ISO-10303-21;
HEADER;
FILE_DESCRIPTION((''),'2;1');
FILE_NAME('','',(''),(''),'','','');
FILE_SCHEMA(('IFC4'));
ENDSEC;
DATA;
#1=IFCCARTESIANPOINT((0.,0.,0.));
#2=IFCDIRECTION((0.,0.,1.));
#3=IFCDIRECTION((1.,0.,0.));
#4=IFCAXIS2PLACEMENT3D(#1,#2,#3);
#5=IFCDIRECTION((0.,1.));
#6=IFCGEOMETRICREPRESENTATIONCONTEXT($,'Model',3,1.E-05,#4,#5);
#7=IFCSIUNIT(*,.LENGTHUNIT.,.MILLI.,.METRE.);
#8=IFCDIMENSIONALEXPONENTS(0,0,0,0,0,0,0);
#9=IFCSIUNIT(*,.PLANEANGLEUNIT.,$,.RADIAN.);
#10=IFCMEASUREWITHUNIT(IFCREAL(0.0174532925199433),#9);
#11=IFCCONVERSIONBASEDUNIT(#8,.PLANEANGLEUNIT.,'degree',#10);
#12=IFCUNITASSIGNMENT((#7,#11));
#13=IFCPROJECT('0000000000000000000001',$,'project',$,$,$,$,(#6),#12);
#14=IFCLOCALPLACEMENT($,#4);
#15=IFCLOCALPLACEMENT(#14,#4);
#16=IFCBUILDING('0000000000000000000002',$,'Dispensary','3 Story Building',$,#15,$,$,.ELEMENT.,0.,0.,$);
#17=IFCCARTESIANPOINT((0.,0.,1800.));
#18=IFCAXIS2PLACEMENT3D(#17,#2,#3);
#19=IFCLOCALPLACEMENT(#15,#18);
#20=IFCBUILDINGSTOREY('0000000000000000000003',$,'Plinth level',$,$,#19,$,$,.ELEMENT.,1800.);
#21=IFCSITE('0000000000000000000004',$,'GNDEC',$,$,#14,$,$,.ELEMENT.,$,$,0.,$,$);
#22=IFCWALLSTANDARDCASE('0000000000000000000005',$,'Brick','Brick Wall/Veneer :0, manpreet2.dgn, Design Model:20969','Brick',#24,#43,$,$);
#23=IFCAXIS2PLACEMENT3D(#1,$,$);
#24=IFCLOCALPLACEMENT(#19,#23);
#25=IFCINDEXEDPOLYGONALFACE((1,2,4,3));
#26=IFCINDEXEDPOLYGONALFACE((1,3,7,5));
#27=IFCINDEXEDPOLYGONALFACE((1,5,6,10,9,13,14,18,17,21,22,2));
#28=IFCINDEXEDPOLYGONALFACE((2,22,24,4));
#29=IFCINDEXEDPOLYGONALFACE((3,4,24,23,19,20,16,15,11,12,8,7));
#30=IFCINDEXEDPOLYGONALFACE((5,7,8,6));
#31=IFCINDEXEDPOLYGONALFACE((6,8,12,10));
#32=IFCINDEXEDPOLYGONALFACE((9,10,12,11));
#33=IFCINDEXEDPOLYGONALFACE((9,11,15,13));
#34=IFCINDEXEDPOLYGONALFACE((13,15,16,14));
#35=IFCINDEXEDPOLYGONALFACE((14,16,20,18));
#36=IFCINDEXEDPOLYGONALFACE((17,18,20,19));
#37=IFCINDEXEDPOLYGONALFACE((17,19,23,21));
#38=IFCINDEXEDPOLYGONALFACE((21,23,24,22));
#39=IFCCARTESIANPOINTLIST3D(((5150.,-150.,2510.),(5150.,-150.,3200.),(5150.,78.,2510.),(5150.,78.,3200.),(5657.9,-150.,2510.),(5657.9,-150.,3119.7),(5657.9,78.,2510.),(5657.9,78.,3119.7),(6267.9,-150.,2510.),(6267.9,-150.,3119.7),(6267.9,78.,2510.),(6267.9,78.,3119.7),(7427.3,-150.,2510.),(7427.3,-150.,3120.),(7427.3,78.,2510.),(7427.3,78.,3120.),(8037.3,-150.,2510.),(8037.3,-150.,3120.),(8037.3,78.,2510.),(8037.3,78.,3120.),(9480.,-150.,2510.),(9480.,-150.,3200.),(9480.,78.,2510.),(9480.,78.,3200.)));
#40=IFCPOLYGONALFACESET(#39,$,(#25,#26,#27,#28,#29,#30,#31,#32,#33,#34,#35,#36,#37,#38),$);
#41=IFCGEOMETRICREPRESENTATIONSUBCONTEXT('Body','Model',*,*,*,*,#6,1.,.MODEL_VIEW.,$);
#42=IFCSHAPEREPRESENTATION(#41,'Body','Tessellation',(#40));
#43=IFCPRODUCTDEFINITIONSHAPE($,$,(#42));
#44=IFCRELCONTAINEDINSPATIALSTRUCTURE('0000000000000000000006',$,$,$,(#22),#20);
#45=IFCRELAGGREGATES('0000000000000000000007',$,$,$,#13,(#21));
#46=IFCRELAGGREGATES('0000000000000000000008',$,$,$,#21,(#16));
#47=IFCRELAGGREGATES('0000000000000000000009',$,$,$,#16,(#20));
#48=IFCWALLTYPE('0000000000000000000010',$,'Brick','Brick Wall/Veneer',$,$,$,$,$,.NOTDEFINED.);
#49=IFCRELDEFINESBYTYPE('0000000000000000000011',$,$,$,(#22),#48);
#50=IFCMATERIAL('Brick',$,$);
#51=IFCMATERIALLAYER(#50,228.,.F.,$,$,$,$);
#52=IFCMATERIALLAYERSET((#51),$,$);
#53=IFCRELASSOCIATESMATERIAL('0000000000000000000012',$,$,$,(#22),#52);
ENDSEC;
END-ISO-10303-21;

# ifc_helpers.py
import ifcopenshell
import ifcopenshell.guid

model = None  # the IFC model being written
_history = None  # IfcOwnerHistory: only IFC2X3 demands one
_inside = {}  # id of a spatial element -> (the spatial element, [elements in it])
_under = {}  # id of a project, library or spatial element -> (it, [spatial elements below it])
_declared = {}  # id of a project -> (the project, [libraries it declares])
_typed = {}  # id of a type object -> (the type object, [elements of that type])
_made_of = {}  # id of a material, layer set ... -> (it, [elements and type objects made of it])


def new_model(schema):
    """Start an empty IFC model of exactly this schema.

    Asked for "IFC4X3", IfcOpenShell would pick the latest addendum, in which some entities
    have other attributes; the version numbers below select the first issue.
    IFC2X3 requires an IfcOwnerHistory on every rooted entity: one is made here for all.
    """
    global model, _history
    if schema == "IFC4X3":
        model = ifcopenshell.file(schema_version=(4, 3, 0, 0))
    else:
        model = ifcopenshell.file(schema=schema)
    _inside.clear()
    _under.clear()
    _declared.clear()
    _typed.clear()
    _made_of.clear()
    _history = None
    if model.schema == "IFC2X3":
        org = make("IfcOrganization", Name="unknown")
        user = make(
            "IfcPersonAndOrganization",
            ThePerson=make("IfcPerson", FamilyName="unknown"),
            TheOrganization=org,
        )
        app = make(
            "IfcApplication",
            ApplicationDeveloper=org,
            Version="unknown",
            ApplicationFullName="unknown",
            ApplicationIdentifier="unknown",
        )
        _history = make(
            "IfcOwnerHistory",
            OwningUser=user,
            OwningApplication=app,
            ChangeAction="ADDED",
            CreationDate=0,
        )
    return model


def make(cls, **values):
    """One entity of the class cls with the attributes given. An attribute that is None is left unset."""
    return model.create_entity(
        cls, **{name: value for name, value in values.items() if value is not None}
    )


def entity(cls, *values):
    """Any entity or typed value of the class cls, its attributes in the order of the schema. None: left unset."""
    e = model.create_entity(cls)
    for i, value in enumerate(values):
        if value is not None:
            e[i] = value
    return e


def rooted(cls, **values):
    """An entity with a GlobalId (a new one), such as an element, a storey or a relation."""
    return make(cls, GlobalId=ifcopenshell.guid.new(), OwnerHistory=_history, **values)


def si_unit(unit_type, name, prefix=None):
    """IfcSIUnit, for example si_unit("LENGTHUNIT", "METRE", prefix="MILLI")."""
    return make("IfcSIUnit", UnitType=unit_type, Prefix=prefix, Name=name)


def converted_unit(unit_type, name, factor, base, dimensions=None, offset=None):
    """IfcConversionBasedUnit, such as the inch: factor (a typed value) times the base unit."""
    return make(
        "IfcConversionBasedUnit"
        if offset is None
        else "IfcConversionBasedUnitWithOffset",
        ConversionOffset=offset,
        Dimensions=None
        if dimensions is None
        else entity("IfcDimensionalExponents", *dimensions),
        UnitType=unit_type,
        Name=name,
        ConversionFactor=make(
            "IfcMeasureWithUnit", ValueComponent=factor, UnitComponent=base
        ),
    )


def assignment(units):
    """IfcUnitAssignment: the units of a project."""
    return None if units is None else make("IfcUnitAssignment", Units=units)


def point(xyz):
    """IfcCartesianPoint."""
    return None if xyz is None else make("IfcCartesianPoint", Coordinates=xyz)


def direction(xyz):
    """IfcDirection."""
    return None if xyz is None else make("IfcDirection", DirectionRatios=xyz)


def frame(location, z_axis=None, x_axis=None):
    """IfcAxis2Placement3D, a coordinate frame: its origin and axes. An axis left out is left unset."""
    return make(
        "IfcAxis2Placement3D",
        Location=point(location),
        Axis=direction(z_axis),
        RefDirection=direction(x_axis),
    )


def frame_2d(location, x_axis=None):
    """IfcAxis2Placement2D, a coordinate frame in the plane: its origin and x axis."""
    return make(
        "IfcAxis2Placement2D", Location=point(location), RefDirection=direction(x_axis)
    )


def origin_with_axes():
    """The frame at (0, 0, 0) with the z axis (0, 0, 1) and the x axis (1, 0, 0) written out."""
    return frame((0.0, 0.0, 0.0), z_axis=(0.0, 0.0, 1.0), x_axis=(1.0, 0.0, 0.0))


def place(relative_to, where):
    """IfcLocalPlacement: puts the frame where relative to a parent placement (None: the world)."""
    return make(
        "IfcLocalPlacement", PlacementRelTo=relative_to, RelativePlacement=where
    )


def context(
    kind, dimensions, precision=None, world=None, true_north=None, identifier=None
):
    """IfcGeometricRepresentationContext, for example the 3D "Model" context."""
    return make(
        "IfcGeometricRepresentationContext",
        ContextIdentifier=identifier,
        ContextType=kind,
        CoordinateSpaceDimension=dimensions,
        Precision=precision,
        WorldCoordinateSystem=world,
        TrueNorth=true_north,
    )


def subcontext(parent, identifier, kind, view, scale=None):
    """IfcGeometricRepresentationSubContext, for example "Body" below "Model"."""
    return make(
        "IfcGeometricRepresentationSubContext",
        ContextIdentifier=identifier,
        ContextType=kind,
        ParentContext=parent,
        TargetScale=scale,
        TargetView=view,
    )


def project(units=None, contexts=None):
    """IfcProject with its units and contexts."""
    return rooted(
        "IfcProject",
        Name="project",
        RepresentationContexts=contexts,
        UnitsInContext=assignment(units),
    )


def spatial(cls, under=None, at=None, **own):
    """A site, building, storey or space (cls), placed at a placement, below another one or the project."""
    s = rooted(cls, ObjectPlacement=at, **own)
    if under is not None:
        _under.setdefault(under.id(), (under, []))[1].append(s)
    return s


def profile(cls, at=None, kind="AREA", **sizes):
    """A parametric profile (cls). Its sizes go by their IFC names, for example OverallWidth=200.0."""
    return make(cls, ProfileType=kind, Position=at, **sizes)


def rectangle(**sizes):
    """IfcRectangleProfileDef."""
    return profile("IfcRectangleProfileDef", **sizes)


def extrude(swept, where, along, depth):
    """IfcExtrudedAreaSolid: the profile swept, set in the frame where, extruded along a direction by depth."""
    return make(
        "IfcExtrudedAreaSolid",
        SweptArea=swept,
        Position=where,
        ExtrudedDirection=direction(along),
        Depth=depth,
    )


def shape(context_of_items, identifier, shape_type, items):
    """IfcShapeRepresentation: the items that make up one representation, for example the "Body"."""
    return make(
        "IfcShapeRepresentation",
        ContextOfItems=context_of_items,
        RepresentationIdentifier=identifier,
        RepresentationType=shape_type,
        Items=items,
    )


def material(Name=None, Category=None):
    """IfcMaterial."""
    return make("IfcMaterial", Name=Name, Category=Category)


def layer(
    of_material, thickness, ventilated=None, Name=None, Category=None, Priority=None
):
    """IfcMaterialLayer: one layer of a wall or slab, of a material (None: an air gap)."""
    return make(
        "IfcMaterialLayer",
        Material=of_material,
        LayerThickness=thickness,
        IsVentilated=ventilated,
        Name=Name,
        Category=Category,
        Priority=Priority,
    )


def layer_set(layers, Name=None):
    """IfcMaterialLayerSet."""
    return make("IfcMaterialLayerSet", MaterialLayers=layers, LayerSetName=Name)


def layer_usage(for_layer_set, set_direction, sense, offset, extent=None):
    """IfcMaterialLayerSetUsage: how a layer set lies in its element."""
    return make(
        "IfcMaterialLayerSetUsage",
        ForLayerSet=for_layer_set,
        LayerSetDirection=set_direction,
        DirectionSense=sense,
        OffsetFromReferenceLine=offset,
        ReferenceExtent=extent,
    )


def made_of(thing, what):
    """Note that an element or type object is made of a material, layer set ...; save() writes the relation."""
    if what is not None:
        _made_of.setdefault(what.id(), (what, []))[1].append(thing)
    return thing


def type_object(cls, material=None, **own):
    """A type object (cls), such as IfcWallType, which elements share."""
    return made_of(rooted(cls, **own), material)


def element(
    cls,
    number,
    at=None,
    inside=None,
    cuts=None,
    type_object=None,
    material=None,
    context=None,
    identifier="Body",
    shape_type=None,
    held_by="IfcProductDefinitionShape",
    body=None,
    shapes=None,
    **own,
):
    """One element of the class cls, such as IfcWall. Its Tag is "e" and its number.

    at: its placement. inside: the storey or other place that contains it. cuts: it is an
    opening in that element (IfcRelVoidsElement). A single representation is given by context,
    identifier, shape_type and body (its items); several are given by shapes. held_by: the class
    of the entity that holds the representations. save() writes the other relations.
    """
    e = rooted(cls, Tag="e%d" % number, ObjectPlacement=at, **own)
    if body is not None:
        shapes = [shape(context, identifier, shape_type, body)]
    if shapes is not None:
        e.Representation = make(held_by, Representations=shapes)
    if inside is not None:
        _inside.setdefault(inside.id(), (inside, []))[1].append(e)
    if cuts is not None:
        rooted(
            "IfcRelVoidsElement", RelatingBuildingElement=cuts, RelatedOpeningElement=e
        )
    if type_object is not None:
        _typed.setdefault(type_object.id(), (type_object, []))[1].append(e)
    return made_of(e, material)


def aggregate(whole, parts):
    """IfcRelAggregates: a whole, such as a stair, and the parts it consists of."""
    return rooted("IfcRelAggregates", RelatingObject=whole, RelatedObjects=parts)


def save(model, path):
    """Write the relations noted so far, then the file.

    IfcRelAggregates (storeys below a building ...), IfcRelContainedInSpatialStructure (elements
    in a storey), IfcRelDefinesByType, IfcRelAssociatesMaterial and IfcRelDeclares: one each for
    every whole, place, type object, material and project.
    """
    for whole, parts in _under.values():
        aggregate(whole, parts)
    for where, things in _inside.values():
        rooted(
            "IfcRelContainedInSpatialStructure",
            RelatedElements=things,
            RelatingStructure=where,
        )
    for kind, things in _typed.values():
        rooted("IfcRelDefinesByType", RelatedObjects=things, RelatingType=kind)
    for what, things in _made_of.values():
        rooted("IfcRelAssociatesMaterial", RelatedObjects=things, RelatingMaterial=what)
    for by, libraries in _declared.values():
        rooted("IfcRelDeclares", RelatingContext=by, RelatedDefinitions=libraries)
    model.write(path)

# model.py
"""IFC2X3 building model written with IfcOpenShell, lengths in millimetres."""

from ifc_helpers import new_model, entity, si_unit, converted_unit, direction, frame, frame_2d, origin_with_axes, place, context, subcontext, project, spatial, rectangle, extrude, material, layer, layer_set, layer_usage, type_object, element, save


model = new_model("IFC2X3")

# Units and contexts
model_context = context("Model", 3, precision=1e-05, world=origin_with_axes(), true_north=direction((0.0, 1.0)))
body_context = subcontext(model_context, "Body", "Model", "MODEL_VIEW", scale=1.0)
ifc_project = project(units=[si_unit("LENGTHUNIT", "METRE", prefix="MILLI"), converted_unit("PLANEANGLEUNIT", "degree", entity("IfcReal", 0.0174532925199433), si_unit("PLANEANGLEUNIT", "RADIAN"), dimensions=[0, 0, 0, 0, 0, 0, 0])], contexts=[model_context])

# Site, building, storey
site_placement = place(None, origin_with_axes())
site = spatial("IfcSite", under=ifc_project, at=site_placement, Name="GNDEC", CompositionType="ELEMENT", RefElevation=0.0)
building_placement = place(site_placement, origin_with_axes())
building = spatial("IfcBuilding", under=site, at=building_placement, Name="Dispensary", Description="3 Story Building", CompositionType="ELEMENT", ElevationOfRefHeight=0.0, ElevationOfTerrain=0.0)
storey_placement = place(building_placement, frame((0.0, 0.0, 1800.0), z_axis=(0.0, 0.0, 1.0), x_axis=(1.0, 0.0, 0.0)))
storey = spatial("IfcBuildingStorey", under=building, at=storey_placement, Name="Plinth level", CompositionType="ELEMENT", Elevation=1800.0)

# Wall, openings
ifc_material_1 = material(Name="Brick")
ifc_layer = layer(ifc_material_1, 228.0, ventilated=False)
ifc_layer_set = layer_set([ifc_layer])
ifc_layer_usage = layer_usage(ifc_layer_set, "AXIS2", "POSITIVE", 0.0)
wall_type = type_object("IfcWallType", Name="Brick", Description="Brick Wall/Veneer", PredefinedType="NOTDEFINED")
wall_1_placement = place(storey_placement, frame((9480.0, -150.0, 2510.0), z_axis=(0.0, 0.0, 1.0), x_axis=(-1.0, 0.0, 0.0)))
wall_1 = element("IfcWallStandardCase", 1, at=wall_1_placement, inside=storey, type_object=wall_type, material=ifc_layer_usage, Name="Brick", Description="Brick Wall/Veneer :0, manpreet2.dgn, Design Model:20969", ObjectType="Brick", context=body_context, shape_type="SweptSolid", body=[
    extrude(rectangle(XDim=4330.0, YDim=228.0, at=frame_2d((2165.0, -114.0), x_axis=(-1.0, 0.0))), origin_with_axes(), (0.0, 0.0, 1.0), 690.0),
])
opening_1_placement = place(wall_1_placement, frame((3212.1, -228.0, -2110.3), z_axis=(0.0, 0.0, 1.0), x_axis=(1.0, 0.0, 0.0)))
element("IfcOpeningElement", 2, at=opening_1_placement, cuts=wall_1, ObjectType="Opening", context=body_context, shape_type="SweptSolid", body=[
    extrude(rectangle(XDim=2720.0, YDim=610.0, at=frame_2d((-305.0, 1360.0), x_axis=(0.0, -1.0))), frame((0.0, 0.0, 0.0), z_axis=(0.0, 1.0, 0.0), x_axis=(-1.0, 0.0, 0.0)), (0.0, 0.0, 1.0), 228.0),
])
opening_2_placement = place(wall_1_placement, frame((1442.7, -228.0, -760.0), z_axis=(0.0, 0.0, 1.0), x_axis=(1.0, 0.0, 0.0)))
element("IfcOpeningElement", 3, at=opening_2_placement, cuts=wall_1, ObjectType="Opening", context=body_context, shape_type="SweptSolid", body=[
    extrude(rectangle(XDim=1370.0, YDim=610.0, at=frame_2d((-305.0, 685.0), x_axis=(0.0, -1.0))), frame((0.0, 0.0, 0.0), z_axis=(0.0, 1.0, 0.0), x_axis=(-1.0, 0.0, 0.0)), (0.0, 0.0, 1.0), 228.0),
])

save(model, "model.ifc")
